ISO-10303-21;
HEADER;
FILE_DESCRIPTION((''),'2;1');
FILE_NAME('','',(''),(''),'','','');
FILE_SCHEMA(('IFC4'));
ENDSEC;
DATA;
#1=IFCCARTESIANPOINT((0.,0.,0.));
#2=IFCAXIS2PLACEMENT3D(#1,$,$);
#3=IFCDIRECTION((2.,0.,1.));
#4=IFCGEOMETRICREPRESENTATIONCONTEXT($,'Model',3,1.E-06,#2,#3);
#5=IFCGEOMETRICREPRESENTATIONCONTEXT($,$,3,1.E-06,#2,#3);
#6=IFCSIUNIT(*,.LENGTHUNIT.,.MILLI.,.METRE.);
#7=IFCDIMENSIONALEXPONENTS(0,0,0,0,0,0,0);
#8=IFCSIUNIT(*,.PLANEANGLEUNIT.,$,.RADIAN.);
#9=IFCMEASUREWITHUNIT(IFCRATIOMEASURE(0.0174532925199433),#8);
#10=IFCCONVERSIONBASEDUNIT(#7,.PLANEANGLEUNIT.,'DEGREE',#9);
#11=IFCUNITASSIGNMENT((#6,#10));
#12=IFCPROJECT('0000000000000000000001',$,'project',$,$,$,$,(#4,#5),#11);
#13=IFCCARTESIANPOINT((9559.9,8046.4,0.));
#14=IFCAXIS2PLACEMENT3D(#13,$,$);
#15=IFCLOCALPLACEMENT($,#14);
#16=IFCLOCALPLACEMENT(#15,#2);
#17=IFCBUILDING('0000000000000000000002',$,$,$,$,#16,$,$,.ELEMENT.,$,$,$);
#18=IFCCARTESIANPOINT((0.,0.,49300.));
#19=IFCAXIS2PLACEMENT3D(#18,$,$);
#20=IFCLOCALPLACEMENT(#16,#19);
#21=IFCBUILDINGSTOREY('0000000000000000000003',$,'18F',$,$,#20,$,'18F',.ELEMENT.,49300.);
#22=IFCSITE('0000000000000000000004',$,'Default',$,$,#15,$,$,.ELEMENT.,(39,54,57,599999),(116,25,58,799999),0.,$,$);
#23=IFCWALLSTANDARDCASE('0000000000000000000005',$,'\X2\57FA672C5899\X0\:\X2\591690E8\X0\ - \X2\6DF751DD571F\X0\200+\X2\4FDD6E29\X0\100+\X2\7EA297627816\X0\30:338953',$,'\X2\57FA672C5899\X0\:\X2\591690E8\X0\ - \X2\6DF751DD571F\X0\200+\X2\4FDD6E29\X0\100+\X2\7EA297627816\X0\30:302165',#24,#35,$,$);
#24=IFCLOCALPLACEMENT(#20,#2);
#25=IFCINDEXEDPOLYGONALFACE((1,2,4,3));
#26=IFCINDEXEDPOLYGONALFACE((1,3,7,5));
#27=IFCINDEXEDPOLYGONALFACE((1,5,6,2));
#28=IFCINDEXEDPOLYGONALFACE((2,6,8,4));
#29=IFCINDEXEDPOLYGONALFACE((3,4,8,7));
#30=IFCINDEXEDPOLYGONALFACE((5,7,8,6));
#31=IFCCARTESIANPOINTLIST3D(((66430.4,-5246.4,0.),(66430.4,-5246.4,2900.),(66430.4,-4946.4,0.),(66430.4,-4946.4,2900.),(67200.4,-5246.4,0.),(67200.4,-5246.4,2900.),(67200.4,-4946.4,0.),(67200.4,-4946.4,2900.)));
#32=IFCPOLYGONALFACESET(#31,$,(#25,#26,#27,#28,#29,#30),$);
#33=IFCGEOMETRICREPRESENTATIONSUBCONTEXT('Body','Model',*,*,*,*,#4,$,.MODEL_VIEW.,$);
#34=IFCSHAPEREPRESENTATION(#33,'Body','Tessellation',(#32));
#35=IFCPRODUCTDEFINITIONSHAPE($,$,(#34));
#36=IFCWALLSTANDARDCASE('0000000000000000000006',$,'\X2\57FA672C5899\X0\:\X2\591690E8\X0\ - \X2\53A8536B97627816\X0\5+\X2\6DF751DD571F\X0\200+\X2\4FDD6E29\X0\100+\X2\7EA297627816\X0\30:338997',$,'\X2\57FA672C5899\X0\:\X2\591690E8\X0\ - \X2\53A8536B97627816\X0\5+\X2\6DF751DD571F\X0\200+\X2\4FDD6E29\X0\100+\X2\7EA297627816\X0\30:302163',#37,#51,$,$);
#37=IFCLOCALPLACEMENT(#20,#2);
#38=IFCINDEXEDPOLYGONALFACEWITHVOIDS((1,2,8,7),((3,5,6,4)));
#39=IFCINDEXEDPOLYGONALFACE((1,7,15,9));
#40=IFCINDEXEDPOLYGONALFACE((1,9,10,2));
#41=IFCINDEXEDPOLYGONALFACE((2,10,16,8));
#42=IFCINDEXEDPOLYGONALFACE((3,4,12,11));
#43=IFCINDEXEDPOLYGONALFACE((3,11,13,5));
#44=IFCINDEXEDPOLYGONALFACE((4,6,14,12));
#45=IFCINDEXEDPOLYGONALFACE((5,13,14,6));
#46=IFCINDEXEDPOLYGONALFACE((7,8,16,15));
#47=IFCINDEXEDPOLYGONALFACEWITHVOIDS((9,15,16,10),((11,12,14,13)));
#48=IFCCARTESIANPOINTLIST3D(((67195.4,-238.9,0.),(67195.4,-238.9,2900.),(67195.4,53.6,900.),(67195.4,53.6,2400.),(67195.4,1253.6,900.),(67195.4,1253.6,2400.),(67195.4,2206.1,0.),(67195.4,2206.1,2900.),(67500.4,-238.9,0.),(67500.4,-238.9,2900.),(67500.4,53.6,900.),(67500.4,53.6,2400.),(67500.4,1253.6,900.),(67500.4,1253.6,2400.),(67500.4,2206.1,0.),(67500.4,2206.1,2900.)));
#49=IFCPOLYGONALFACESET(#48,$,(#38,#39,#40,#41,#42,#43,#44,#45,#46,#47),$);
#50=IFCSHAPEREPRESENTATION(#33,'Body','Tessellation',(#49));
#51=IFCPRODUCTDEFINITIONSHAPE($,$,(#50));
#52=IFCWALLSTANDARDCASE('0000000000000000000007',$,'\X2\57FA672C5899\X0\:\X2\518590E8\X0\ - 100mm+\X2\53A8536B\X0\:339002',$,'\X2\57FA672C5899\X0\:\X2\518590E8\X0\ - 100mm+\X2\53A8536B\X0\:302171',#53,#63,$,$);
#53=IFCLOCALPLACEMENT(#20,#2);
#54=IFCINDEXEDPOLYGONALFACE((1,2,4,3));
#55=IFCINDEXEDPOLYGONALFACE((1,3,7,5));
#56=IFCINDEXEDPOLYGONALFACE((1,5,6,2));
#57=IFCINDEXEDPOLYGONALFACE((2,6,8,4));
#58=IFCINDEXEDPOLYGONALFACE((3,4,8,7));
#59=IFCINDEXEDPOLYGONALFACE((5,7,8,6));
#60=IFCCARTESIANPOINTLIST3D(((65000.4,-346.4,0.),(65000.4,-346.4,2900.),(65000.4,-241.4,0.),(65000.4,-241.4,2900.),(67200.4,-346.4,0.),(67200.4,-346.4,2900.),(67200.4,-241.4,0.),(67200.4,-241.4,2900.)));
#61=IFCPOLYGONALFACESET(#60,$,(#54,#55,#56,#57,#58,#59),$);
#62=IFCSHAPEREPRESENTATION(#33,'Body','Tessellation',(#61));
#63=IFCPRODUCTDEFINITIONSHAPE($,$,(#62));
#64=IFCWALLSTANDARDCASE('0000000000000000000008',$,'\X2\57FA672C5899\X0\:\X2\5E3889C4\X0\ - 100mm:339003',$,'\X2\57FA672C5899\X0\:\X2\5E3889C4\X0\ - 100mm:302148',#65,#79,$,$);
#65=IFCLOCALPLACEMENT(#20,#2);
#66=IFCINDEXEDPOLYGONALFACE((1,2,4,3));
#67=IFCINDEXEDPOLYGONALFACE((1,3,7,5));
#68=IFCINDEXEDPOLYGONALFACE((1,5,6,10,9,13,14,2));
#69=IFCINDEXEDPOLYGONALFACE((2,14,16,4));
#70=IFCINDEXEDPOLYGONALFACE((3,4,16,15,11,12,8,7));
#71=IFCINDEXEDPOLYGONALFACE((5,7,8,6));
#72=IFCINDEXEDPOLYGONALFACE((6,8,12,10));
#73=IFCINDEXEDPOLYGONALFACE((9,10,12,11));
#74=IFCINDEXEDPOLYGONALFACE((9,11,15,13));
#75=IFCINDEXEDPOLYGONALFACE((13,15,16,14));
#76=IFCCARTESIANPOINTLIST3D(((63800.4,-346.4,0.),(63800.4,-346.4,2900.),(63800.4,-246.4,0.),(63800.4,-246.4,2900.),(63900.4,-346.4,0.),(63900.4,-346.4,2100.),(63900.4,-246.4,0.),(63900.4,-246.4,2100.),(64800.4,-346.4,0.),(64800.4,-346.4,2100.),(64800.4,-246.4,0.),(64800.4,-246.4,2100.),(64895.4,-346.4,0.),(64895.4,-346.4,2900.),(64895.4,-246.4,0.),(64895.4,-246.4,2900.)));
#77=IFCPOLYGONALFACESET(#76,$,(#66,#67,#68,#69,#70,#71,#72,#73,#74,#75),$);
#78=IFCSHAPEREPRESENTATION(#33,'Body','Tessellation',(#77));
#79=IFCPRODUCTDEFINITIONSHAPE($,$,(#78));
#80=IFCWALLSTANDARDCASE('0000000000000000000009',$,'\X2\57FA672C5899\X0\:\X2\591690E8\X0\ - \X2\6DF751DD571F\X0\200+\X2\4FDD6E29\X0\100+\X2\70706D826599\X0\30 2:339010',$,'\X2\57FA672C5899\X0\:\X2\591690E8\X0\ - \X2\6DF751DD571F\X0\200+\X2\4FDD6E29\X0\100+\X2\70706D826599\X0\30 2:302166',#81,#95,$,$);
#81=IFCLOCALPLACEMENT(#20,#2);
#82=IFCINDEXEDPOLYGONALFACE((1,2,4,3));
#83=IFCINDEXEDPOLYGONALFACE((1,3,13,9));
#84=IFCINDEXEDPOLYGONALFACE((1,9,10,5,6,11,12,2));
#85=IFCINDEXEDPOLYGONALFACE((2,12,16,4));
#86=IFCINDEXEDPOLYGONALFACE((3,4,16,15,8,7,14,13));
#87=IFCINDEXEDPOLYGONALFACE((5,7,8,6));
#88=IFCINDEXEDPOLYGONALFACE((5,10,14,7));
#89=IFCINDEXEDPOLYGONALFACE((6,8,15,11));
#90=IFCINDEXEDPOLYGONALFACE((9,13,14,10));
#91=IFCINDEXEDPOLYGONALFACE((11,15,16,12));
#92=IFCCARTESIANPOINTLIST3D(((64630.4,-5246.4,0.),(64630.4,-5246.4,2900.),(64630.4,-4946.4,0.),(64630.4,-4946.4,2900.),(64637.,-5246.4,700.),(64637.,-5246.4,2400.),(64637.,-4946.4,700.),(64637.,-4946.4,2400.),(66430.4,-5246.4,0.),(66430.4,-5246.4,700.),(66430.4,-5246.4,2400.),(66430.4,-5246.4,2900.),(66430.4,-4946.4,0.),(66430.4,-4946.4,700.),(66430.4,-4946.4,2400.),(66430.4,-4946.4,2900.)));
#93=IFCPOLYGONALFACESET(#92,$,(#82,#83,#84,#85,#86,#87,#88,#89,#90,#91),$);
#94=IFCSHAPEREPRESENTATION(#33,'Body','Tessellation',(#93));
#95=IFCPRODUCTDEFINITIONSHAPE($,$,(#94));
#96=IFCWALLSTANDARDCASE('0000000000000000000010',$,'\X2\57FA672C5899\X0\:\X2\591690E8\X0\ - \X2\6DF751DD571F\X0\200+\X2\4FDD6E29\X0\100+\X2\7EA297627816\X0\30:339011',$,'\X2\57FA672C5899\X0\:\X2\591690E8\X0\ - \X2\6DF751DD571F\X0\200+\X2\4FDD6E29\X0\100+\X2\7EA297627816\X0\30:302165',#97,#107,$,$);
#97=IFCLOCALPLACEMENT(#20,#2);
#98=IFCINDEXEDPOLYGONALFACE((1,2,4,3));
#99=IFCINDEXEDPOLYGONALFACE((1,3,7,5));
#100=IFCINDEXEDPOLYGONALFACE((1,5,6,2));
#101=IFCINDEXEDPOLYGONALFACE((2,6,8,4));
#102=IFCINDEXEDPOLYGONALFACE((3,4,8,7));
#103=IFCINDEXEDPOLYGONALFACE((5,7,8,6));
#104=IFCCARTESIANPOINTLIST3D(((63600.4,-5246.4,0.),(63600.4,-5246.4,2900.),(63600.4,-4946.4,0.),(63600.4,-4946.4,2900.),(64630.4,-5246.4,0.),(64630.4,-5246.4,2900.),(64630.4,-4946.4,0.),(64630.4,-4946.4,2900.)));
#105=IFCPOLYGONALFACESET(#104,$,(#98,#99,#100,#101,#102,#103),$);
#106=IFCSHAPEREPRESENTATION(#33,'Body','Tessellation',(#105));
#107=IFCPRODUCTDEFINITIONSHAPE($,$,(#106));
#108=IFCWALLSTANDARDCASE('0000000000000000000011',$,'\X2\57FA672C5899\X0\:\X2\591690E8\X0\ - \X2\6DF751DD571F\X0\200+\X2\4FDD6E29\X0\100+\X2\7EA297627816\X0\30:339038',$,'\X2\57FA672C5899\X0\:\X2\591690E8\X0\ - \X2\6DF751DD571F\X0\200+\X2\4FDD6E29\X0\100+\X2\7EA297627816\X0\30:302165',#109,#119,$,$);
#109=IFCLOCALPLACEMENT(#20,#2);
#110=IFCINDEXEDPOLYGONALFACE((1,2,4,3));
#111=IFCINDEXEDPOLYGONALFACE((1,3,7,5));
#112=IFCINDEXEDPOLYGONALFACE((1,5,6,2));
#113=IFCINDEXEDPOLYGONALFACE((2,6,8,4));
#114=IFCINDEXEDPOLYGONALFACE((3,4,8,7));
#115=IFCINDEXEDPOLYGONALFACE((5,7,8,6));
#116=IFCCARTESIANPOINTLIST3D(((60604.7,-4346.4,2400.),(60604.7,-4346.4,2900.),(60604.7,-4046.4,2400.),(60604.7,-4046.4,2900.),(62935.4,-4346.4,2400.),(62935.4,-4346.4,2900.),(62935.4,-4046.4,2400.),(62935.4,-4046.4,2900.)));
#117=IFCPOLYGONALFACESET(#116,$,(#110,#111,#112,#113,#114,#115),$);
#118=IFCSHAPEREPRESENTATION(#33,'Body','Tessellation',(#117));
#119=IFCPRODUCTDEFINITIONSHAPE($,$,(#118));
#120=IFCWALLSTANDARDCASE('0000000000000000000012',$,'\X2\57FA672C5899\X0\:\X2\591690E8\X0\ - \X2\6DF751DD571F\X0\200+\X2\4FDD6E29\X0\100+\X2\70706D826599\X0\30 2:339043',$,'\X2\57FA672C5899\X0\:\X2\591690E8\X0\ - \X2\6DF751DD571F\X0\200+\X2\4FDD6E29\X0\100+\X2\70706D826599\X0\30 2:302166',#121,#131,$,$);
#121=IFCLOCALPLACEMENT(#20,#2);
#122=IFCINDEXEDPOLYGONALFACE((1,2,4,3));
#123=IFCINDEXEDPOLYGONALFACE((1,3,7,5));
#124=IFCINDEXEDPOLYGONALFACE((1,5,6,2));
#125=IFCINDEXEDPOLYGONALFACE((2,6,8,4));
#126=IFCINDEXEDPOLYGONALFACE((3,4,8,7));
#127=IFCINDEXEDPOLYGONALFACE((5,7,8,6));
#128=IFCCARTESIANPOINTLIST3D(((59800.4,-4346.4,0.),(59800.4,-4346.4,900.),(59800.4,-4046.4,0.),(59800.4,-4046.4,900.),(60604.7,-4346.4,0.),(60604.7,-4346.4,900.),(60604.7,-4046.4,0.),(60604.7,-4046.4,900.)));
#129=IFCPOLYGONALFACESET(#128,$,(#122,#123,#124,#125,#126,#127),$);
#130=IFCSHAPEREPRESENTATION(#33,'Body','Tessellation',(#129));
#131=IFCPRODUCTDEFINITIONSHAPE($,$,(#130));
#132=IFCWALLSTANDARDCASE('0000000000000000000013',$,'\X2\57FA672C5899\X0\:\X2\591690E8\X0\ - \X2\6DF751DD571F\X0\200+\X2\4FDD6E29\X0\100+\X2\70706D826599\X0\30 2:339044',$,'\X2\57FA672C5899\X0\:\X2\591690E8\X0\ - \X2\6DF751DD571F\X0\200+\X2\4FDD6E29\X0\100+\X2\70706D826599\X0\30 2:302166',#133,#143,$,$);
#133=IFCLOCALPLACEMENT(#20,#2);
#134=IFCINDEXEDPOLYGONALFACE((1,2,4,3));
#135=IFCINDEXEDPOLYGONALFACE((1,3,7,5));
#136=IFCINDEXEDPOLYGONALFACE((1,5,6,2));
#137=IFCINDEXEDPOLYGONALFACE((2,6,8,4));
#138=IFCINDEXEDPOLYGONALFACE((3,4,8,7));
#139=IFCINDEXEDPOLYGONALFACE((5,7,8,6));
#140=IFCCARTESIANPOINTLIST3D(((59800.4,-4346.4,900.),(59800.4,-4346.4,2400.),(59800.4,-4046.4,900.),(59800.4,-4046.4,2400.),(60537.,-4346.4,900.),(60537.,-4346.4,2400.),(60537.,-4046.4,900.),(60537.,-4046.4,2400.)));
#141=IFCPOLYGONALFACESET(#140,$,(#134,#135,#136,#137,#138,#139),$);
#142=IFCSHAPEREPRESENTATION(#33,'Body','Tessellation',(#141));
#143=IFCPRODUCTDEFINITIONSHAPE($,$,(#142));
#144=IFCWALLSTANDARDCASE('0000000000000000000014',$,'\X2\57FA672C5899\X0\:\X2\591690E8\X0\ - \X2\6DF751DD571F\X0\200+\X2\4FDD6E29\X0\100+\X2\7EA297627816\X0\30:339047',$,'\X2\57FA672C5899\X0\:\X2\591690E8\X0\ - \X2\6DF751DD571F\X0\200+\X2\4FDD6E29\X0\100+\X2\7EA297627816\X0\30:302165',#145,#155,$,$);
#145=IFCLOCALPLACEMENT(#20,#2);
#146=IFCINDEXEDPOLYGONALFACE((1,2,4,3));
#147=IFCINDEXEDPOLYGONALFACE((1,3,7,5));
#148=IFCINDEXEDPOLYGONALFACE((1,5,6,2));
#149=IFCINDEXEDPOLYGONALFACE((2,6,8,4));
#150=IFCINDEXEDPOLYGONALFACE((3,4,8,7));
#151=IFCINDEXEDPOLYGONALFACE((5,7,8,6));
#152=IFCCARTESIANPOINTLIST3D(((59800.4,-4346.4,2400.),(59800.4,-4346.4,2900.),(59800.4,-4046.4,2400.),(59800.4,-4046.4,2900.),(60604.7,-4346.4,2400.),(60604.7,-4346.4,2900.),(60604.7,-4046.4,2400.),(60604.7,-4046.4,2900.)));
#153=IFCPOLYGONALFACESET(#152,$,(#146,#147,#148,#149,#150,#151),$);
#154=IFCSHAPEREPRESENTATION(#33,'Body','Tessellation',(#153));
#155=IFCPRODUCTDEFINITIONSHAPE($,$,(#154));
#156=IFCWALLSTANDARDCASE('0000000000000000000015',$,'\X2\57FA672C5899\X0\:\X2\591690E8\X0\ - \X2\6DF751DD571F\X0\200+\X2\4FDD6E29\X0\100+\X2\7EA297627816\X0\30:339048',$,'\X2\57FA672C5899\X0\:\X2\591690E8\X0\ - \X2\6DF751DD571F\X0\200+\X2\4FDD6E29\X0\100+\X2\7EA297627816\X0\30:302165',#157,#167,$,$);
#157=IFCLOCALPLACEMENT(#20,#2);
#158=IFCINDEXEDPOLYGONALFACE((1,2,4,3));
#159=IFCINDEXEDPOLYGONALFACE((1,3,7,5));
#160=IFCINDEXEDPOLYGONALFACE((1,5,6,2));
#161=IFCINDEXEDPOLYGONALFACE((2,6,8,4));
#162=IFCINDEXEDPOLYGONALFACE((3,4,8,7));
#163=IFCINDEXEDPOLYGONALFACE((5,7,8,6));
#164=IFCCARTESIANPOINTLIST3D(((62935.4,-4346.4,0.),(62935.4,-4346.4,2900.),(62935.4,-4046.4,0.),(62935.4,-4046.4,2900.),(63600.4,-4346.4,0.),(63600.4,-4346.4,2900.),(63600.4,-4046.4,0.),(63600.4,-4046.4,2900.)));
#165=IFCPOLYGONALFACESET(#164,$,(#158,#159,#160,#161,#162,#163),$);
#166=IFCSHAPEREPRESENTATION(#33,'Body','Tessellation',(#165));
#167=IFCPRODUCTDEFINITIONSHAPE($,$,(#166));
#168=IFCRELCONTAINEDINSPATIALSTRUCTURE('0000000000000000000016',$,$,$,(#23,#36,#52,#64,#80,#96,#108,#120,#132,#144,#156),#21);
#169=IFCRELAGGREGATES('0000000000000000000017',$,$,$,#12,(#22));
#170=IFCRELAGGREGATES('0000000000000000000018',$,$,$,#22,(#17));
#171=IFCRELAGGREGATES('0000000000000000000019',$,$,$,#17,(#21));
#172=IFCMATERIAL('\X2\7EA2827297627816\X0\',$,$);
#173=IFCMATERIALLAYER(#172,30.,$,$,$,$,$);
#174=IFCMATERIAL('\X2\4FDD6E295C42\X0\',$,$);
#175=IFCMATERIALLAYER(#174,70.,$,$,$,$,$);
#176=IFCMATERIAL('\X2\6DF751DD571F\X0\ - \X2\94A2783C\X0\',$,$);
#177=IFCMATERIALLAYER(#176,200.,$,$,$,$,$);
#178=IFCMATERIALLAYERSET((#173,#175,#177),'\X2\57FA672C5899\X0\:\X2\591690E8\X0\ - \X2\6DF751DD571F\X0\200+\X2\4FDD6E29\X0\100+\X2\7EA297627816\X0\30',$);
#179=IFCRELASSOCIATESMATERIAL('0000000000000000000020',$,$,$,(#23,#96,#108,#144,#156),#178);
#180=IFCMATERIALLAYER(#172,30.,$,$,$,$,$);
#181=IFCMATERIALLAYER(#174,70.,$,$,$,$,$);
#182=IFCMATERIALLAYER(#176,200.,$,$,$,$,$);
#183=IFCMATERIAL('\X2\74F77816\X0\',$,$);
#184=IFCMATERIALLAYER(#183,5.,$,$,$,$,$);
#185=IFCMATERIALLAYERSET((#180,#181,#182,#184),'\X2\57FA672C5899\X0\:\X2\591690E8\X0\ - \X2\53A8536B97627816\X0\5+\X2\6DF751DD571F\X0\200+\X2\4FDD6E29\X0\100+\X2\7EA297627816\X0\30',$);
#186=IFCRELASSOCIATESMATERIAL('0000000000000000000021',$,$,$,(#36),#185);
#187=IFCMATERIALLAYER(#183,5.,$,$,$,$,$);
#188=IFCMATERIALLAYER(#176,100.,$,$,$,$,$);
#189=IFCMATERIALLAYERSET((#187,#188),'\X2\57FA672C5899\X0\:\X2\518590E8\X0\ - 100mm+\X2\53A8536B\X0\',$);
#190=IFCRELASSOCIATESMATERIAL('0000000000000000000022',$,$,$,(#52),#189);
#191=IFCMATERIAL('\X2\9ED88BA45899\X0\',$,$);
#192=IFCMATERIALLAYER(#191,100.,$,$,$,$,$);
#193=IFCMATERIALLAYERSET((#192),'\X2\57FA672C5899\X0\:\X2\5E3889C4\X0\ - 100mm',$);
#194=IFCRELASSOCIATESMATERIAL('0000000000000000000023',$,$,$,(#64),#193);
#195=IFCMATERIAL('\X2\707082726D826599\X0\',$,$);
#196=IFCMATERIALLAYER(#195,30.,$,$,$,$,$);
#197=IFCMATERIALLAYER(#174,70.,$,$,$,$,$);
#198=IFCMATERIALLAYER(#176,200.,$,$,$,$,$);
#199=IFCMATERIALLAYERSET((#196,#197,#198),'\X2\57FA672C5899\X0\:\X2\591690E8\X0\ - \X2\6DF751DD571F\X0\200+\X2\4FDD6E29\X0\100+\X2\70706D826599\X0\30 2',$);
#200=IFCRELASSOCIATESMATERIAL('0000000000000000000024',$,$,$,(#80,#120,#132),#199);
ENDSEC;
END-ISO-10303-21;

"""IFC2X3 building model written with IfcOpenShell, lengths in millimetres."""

from ifc_helpers import new_model, entity, si_unit, converted_unit, direction, frame, frame_2d, origin, place, context, subcontext, project, spatial, rectangle, extrude, material, layer, layer_set, layer_usage, element, save


model = new_model("IFC2X3")

# Units and contexts
model_context = context("Model", 3, precision=1e-06, world=origin(), true_north=direction((2.0, 0.0, 1.0)))
context_of_model = context(None, 3, precision=1e-06, world=origin(), true_north=direction((2.0, 0.0, 1.0)))
body_context = subcontext(model_context, "Body", "Model", "MODEL_VIEW")
ifc_project = project(units=[si_unit("LENGTHUNIT", "METRE", prefix="MILLI"), converted_unit("PLANEANGLEUNIT", "DEGREE", entity("IfcRatioMeasure", 0.0174532925199433), si_unit("PLANEANGLEUNIT", "RADIAN"), dimensions=[0, 0, 0, 0, 0, 0, 0])], contexts=[model_context, context_of_model])

# Site, building, storey
site_placement = place(None, frame((9559.9, 8046.4, 0.0)))
site = spatial("IfcSite", under=ifc_project, at=site_placement, Name="Default", CompositionType="ELEMENT", RefLatitude=(39, 54, 57, 599999), RefLongitude=(116, 25, 58, 799999), RefElevation=0.0)
building_placement = place(site_placement, origin())
building = spatial("IfcBuilding", under=site, at=building_placement, CompositionType="ELEMENT")
storey_placement = place(building_placement, frame((0.0, 0.0, 49300.0)))
storey = spatial("IfcBuildingStorey", under=building, at=storey_placement, Name="18F", LongName="18F", CompositionType="ELEMENT", Elevation=49300.0)

# Shared definitions
ifc_material_1 = material(Name="默认墙")

# Shared definitions
ifc_material_2 = material(Name="保温层")
ifc_material_3 = material(Name="混凝土 - 钢砼")
ifc_material_4 = material(Name="灰色涂料")
ifc_layer_1 = layer(ifc_material_4, 30.0)
ifc_layer_2 = layer(ifc_material_2, 70.0)
ifc_layer_3 = layer(ifc_material_3, 200.0)
ifc_layer_set_1 = layer_set([ifc_layer_1, ifc_layer_2, ifc_layer_3], Name="基本墙:外部 - 混凝土200+保温100+灰涂料30 2")

# Shared definitions
ifc_material_5 = material(Name="红色面砖")
ifc_layer_4 = layer(ifc_material_5, 30.0)
ifc_layer_5 = layer(ifc_material_2, 70.0)
ifc_layer_6 = layer(ifc_material_3, 200.0)
ifc_layer_set_2 = layer_set([ifc_layer_4, ifc_layer_5, ifc_layer_6], Name="基本墙:外部 - 混凝土200+保温100+红面砖30")

# Wall
ifc_layer_usage_1 = layer_usage(ifc_layer_set_2, "AXIS2", "NEGATIVE", 150.0)
wall_1_placement = place(storey_placement, frame((67200.4, -5096.4, 0.0), z_axis=(0.0, 0.0, 1.0), x_axis=(-1.0, 0.0, 0.0)))
element("IfcWallStandardCase", 1, at=wall_1_placement, inside=storey, material=ifc_layer_usage_1, Name="基本墙:外部 - 混凝土200+保温100+红面砖30:338953", ObjectType="基本墙:外部 - 混凝土200+保温100+红面砖30:302165", context=body_context, shape_type="SweptSolid", body=[
    extrude(rectangle(XDim=770.0, YDim=300.0, at=frame_2d((385.0, 0.0), x_axis=(-1.0, 0.0))), origin(), (0.0, 0.0, 1.0), 2900.0),
])

# Wall, opening
ifc_layer_7 = layer(ifc_material_5, 30.0)
ifc_layer_8 = layer(ifc_material_2, 70.0)
ifc_layer_9 = layer(ifc_material_3, 200.0)
ifc_material_6 = material(Name="瓷砖")
ifc_layer_10 = layer(ifc_material_6, 5.0)
ifc_layer_set_3 = layer_set([ifc_layer_7, ifc_layer_8, ifc_layer_9, ifc_layer_10], Name="基本墙:外部 - 厨卫面砖5+混凝土200+保温100+红面砖30")
ifc_layer_usage_2 = layer_usage(ifc_layer_set_3, "AXIS2", "POSITIVE", -152.5)
wall_2_placement = place(storey_placement, frame((67347.9, -238.9, 0.0), z_axis=(0.0, 0.0, 1.0), x_axis=(0.0, 1.0, 0.0)))
wall_2 = element("IfcWallStandardCase", 2, at=wall_2_placement, inside=storey, material=ifc_layer_usage_2, Name="基本墙:外部 - 厨卫面砖5+混凝土200+保温100+红面砖30:338997", ObjectType="基本墙:外部 - 厨卫面砖5+混凝土200+保温100+红面砖30:302163", context=body_context, shape_type="SweptSolid", body=[
    extrude(rectangle(XDim=2445.0, YDim=305.0, at=frame_2d((1222.5, 0.0), x_axis=(-1.0, 0.0))), origin(), (0.0, 0.0, 1.0), 2900.0),
])
opening_1_placement = place(wall_2_placement, frame((1492.5, 152.5, 900.0)))
element("IfcOpeningElement", 3, at=opening_1_placement, cuts=wall_2, ObjectType="Opening", context=body_context, shape_type="SweptSolid", body=[
    extrude(rectangle(XDim=1500.0, YDim=1200.0, at=frame_2d((750.0, 600.0), x_axis=(1.0, 0.0))), frame((0.0, 0.0, 0.0), z_axis=(0.0, -1.0, 0.0), x_axis=(0.0, 0.0, 1.0)), (0.0, 0.0, 1.0), 305.0),
])

# Wall
ifc_layer_11 = layer(ifc_material_6, 5.0)
ifc_layer_12 = layer(ifc_material_3, 100.0)
ifc_layer_set_4 = layer_set([ifc_layer_11, ifc_layer_12], Name="基本墙:内部 - 100mm+厨卫")
ifc_layer_usage_3 = layer_usage(ifc_layer_set_4, "AXIS2", "POSITIVE", -52.5)
wall_3_placement = place(storey_placement, frame((67200.4, -293.9, 0.0), z_axis=(0.0, 0.0, 1.0), x_axis=(-1.0, 0.0, 0.0)))
element("IfcWallStandardCase", 4, at=wall_3_placement, inside=storey, material=ifc_layer_usage_3, Name="基本墙:内部 - 100mm+厨卫:339002", ObjectType="基本墙:内部 - 100mm+厨卫:302171", context=body_context, shape_type="SweptSolid", body=[
    extrude(rectangle(XDim=2200.0, YDim=105.0, at=frame_2d((1100.0, 0.0), x_axis=(-1.0, 0.0))), origin(), (0.0, 0.0, 1.0), 2900.0),
])

# Walls, openings
ifc_layer_13 = layer(ifc_material_1, 100.0)
ifc_layer_set_5 = layer_set([ifc_layer_13], Name="基本墙:常规 - 100mm")
ifc_layer_usage_4 = layer_usage(ifc_layer_set_5, "AXIS2", "POSITIVE", -50.0)
wall_4_placement = place(storey_placement, frame((64895.4, -296.4, 0.0), z_axis=(0.0, 0.0, 1.0), x_axis=(-1.0, 0.0, 0.0)))
wall_4 = element("IfcWallStandardCase", 5, at=wall_4_placement, inside=storey, material=ifc_layer_usage_4, Name="基本墙:常规 - 100mm:339003", ObjectType="基本墙:常规 - 100mm:302148", context=body_context, shape_type="SweptSolid", body=[
    extrude(rectangle(XDim=1095.0, YDim=100.0, at=frame_2d((547.5, 0.0), x_axis=(-1.0, 0.0))), origin(), (0.0, 0.0, 1.0), 2900.0),
])
opening_2_placement = place(wall_4_placement, frame((95.0, -50.0, 0.0)))
element("IfcOpeningElement", 6, at=opening_2_placement, cuts=wall_4, ObjectType="Opening", context=body_context, shape_type="SweptSolid", body=[
    extrude(rectangle(XDim=2100.0, YDim=900.0, at=frame_2d((1050.0, 450.0), x_axis=(1.0, 0.0))), frame((0.0, 0.0, 0.0), z_axis=(0.0, 1.0, 0.0), x_axis=(0.0, 0.0, 1.0)), (0.0, 0.0, 1.0), 100.0),
])
ifc_layer_usage_5 = layer_usage(ifc_layer_set_1, "AXIS2", "NEGATIVE", 150.0)
wall_5_placement = place(storey_placement, frame((66430.4, -5096.4, 0.0), z_axis=(0.0, 0.0, 1.0), x_axis=(-1.0, 0.0, 0.0)))
wall_5 = element("IfcWallStandardCase", 7, at=wall_5_placement, inside=storey, material=ifc_layer_usage_5, Name="基本墙:外部 - 混凝土200+保温100+灰涂料30 2:339010", ObjectType="基本墙:外部 - 混凝土200+保温100+灰涂料30 2:302166", context=body_context, shape_type="SweptSolid", body=[
    extrude(rectangle(XDim=1800.0, YDim=300.0, at=frame_2d((900.0, 0.0), x_axis=(-1.0, 0.0))), origin(), (0.0, 0.0, 1.0), 2900.0),
])
opening_3_placement = place(wall_5_placement, frame((-6.6, -150.0, 700.0)))
element("IfcOpeningElement", 8, at=opening_3_placement, cuts=wall_5, ObjectType="Opening", context=body_context, shape_type="SweptSolid", body=[
    extrude(rectangle(XDim=1700.0, YDim=1800.0, at=frame_2d((850.0, 900.0), x_axis=(1.0, 0.0))), frame((0.0, 0.0, 0.0), z_axis=(0.0, 1.0, 0.0), x_axis=(0.0, 0.0, 1.0)), (0.0, 0.0, 1.0), 300.0),
])

# Walls
ifc_layer_usage_6 = layer_usage(ifc_layer_set_2, "AXIS2", "NEGATIVE", 150.0)
wall_6_placement = place(storey_placement, frame((64630.4, -5096.4, 0.0), z_axis=(0.0, 0.0, 1.0), x_axis=(-1.0, 0.0, 0.0)))
element("IfcWallStandardCase", 9, at=wall_6_placement, inside=storey, material=ifc_layer_usage_6, Name="基本墙:外部 - 混凝土200+保温100+红面砖30:339011", ObjectType="基本墙:外部 - 混凝土200+保温100+红面砖30:302165", context=body_context, shape_type="SweptSolid", body=[
    extrude(rectangle(XDim=1030.0, YDim=300.0, at=frame_2d((515.0, 0.0), x_axis=(-1.0, 0.0))), origin(), (0.0, 0.0, 1.0), 2900.0),
])
ifc_layer_usage_7 = layer_usage(ifc_layer_set_2, "AXIS2", "NEGATIVE", 150.0)
wall_7_placement = place(storey_placement, frame((62935.4, -4196.4, 2400.0), z_axis=(0.0, 0.0, 1.0), x_axis=(-1.0, 0.0, 0.0)))
element("IfcWallStandardCase", 10, at=wall_7_placement, inside=storey, material=ifc_layer_usage_7, Name="基本墙:外部 - 混凝土200+保温100+红面砖30:339038", ObjectType="基本墙:外部 - 混凝土200+保温100+红面砖30:302165", context=body_context, shape_type="SweptSolid", body=[
    extrude(rectangle(XDim=2330.6, YDim=300.0, at=frame_2d((1165.3, 0.0), x_axis=(-1.0, 0.0))), origin(), (0.0, 0.0, 1.0), 500.0),
])

# Walls
ifc_layer_usage_8 = layer_usage(ifc_layer_set_1, "AXIS2", "NEGATIVE", 150.0)
wall_8_placement = place(storey_placement, frame((60604.7, -4196.4, 0.0), z_axis=(0.0, 0.0, 1.0), x_axis=(-1.0, 0.0, 0.0)))
element("IfcWallStandardCase", 11, at=wall_8_placement, inside=storey, material=ifc_layer_usage_8, Name="基本墙:外部 - 混凝土200+保温100+灰涂料30 2:339043", ObjectType="基本墙:外部 - 混凝土200+保温100+灰涂料30 2:302166", context=body_context, shape_type="SweptSolid", body=[
    extrude(rectangle(XDim=804.4, YDim=300.0, at=frame_2d((402.2, 0.0), x_axis=(-1.0, 0.0))), origin(), (0.0, 0.0, 1.0), 900.0),
])
ifc_layer_usage_9 = layer_usage(ifc_layer_set_1, "AXIS2", "NEGATIVE", 150.0)
wall_9_placement = place(storey_placement, frame((60537.0, -4196.4, 900.0), z_axis=(0.0, 0.0, 1.0), x_axis=(-1.0, 0.0, 0.0)))
element("IfcWallStandardCase", 12, at=wall_9_placement, inside=storey, material=ifc_layer_usage_9, Name="基本墙:外部 - 混凝土200+保温100+灰涂料30 2:339044", ObjectType="基本墙:外部 - 混凝土200+保温100+灰涂料30 2:302166", context=body_context, shape_type="SweptSolid", body=[
    extrude(rectangle(XDim=736.6, YDim=300.0, at=frame_2d((368.3, 0.0), x_axis=(-1.0, 0.0))), origin(), (0.0, 0.0, 1.0), 1500.0),
])
ifc_layer_usage_10 = layer_usage(ifc_layer_set_2, "AXIS2", "NEGATIVE", 150.0)
wall_10_placement = place(storey_placement, frame((60604.7, -4196.4, 2400.0), z_axis=(0.0, 0.0, 1.0), x_axis=(-1.0, 0.0, 0.0)))
element("IfcWallStandardCase", 13, at=wall_10_placement, inside=storey, material=ifc_layer_usage_10, Name="基本墙:外部 - 混凝土200+保温100+红面砖30:339047", ObjectType="基本墙:外部 - 混凝土200+保温100+红面砖30:302165", context=body_context, shape_type="SweptSolid", body=[
    extrude(rectangle(XDim=804.4, YDim=300.0, at=frame_2d((402.2, 0.0), x_axis=(-1.0, 0.0))), origin(), (0.0, 0.0, 1.0), 500.0),
])
ifc_layer_usage_11 = layer_usage(ifc_layer_set_2, "AXIS2", "NEGATIVE", 150.0)
wall_11_placement = place(storey_placement, frame((63600.4, -4196.4, 0.0), z_axis=(0.0, 0.0, 1.0), x_axis=(-1.0, 0.0, 0.0)))
element("IfcWallStandardCase", 14, at=wall_11_placement, inside=storey, material=ifc_layer_usage_11, Name="基本墙:外部 - 混凝土200+保温100+红面砖30:339048", ObjectType="基本墙:外部 - 混凝土200+保温100+红面砖30:302165", context=body_context, shape_type="SweptSolid", body=[
    extrude(rectangle(XDim=665.0, YDim=300.0, at=frame_2d((332.5, 0.0), x_axis=(-1.0, 0.0))), origin(), (0.0, 0.0, 1.0), 2900.0),
])

save(model, "model.ifc")
